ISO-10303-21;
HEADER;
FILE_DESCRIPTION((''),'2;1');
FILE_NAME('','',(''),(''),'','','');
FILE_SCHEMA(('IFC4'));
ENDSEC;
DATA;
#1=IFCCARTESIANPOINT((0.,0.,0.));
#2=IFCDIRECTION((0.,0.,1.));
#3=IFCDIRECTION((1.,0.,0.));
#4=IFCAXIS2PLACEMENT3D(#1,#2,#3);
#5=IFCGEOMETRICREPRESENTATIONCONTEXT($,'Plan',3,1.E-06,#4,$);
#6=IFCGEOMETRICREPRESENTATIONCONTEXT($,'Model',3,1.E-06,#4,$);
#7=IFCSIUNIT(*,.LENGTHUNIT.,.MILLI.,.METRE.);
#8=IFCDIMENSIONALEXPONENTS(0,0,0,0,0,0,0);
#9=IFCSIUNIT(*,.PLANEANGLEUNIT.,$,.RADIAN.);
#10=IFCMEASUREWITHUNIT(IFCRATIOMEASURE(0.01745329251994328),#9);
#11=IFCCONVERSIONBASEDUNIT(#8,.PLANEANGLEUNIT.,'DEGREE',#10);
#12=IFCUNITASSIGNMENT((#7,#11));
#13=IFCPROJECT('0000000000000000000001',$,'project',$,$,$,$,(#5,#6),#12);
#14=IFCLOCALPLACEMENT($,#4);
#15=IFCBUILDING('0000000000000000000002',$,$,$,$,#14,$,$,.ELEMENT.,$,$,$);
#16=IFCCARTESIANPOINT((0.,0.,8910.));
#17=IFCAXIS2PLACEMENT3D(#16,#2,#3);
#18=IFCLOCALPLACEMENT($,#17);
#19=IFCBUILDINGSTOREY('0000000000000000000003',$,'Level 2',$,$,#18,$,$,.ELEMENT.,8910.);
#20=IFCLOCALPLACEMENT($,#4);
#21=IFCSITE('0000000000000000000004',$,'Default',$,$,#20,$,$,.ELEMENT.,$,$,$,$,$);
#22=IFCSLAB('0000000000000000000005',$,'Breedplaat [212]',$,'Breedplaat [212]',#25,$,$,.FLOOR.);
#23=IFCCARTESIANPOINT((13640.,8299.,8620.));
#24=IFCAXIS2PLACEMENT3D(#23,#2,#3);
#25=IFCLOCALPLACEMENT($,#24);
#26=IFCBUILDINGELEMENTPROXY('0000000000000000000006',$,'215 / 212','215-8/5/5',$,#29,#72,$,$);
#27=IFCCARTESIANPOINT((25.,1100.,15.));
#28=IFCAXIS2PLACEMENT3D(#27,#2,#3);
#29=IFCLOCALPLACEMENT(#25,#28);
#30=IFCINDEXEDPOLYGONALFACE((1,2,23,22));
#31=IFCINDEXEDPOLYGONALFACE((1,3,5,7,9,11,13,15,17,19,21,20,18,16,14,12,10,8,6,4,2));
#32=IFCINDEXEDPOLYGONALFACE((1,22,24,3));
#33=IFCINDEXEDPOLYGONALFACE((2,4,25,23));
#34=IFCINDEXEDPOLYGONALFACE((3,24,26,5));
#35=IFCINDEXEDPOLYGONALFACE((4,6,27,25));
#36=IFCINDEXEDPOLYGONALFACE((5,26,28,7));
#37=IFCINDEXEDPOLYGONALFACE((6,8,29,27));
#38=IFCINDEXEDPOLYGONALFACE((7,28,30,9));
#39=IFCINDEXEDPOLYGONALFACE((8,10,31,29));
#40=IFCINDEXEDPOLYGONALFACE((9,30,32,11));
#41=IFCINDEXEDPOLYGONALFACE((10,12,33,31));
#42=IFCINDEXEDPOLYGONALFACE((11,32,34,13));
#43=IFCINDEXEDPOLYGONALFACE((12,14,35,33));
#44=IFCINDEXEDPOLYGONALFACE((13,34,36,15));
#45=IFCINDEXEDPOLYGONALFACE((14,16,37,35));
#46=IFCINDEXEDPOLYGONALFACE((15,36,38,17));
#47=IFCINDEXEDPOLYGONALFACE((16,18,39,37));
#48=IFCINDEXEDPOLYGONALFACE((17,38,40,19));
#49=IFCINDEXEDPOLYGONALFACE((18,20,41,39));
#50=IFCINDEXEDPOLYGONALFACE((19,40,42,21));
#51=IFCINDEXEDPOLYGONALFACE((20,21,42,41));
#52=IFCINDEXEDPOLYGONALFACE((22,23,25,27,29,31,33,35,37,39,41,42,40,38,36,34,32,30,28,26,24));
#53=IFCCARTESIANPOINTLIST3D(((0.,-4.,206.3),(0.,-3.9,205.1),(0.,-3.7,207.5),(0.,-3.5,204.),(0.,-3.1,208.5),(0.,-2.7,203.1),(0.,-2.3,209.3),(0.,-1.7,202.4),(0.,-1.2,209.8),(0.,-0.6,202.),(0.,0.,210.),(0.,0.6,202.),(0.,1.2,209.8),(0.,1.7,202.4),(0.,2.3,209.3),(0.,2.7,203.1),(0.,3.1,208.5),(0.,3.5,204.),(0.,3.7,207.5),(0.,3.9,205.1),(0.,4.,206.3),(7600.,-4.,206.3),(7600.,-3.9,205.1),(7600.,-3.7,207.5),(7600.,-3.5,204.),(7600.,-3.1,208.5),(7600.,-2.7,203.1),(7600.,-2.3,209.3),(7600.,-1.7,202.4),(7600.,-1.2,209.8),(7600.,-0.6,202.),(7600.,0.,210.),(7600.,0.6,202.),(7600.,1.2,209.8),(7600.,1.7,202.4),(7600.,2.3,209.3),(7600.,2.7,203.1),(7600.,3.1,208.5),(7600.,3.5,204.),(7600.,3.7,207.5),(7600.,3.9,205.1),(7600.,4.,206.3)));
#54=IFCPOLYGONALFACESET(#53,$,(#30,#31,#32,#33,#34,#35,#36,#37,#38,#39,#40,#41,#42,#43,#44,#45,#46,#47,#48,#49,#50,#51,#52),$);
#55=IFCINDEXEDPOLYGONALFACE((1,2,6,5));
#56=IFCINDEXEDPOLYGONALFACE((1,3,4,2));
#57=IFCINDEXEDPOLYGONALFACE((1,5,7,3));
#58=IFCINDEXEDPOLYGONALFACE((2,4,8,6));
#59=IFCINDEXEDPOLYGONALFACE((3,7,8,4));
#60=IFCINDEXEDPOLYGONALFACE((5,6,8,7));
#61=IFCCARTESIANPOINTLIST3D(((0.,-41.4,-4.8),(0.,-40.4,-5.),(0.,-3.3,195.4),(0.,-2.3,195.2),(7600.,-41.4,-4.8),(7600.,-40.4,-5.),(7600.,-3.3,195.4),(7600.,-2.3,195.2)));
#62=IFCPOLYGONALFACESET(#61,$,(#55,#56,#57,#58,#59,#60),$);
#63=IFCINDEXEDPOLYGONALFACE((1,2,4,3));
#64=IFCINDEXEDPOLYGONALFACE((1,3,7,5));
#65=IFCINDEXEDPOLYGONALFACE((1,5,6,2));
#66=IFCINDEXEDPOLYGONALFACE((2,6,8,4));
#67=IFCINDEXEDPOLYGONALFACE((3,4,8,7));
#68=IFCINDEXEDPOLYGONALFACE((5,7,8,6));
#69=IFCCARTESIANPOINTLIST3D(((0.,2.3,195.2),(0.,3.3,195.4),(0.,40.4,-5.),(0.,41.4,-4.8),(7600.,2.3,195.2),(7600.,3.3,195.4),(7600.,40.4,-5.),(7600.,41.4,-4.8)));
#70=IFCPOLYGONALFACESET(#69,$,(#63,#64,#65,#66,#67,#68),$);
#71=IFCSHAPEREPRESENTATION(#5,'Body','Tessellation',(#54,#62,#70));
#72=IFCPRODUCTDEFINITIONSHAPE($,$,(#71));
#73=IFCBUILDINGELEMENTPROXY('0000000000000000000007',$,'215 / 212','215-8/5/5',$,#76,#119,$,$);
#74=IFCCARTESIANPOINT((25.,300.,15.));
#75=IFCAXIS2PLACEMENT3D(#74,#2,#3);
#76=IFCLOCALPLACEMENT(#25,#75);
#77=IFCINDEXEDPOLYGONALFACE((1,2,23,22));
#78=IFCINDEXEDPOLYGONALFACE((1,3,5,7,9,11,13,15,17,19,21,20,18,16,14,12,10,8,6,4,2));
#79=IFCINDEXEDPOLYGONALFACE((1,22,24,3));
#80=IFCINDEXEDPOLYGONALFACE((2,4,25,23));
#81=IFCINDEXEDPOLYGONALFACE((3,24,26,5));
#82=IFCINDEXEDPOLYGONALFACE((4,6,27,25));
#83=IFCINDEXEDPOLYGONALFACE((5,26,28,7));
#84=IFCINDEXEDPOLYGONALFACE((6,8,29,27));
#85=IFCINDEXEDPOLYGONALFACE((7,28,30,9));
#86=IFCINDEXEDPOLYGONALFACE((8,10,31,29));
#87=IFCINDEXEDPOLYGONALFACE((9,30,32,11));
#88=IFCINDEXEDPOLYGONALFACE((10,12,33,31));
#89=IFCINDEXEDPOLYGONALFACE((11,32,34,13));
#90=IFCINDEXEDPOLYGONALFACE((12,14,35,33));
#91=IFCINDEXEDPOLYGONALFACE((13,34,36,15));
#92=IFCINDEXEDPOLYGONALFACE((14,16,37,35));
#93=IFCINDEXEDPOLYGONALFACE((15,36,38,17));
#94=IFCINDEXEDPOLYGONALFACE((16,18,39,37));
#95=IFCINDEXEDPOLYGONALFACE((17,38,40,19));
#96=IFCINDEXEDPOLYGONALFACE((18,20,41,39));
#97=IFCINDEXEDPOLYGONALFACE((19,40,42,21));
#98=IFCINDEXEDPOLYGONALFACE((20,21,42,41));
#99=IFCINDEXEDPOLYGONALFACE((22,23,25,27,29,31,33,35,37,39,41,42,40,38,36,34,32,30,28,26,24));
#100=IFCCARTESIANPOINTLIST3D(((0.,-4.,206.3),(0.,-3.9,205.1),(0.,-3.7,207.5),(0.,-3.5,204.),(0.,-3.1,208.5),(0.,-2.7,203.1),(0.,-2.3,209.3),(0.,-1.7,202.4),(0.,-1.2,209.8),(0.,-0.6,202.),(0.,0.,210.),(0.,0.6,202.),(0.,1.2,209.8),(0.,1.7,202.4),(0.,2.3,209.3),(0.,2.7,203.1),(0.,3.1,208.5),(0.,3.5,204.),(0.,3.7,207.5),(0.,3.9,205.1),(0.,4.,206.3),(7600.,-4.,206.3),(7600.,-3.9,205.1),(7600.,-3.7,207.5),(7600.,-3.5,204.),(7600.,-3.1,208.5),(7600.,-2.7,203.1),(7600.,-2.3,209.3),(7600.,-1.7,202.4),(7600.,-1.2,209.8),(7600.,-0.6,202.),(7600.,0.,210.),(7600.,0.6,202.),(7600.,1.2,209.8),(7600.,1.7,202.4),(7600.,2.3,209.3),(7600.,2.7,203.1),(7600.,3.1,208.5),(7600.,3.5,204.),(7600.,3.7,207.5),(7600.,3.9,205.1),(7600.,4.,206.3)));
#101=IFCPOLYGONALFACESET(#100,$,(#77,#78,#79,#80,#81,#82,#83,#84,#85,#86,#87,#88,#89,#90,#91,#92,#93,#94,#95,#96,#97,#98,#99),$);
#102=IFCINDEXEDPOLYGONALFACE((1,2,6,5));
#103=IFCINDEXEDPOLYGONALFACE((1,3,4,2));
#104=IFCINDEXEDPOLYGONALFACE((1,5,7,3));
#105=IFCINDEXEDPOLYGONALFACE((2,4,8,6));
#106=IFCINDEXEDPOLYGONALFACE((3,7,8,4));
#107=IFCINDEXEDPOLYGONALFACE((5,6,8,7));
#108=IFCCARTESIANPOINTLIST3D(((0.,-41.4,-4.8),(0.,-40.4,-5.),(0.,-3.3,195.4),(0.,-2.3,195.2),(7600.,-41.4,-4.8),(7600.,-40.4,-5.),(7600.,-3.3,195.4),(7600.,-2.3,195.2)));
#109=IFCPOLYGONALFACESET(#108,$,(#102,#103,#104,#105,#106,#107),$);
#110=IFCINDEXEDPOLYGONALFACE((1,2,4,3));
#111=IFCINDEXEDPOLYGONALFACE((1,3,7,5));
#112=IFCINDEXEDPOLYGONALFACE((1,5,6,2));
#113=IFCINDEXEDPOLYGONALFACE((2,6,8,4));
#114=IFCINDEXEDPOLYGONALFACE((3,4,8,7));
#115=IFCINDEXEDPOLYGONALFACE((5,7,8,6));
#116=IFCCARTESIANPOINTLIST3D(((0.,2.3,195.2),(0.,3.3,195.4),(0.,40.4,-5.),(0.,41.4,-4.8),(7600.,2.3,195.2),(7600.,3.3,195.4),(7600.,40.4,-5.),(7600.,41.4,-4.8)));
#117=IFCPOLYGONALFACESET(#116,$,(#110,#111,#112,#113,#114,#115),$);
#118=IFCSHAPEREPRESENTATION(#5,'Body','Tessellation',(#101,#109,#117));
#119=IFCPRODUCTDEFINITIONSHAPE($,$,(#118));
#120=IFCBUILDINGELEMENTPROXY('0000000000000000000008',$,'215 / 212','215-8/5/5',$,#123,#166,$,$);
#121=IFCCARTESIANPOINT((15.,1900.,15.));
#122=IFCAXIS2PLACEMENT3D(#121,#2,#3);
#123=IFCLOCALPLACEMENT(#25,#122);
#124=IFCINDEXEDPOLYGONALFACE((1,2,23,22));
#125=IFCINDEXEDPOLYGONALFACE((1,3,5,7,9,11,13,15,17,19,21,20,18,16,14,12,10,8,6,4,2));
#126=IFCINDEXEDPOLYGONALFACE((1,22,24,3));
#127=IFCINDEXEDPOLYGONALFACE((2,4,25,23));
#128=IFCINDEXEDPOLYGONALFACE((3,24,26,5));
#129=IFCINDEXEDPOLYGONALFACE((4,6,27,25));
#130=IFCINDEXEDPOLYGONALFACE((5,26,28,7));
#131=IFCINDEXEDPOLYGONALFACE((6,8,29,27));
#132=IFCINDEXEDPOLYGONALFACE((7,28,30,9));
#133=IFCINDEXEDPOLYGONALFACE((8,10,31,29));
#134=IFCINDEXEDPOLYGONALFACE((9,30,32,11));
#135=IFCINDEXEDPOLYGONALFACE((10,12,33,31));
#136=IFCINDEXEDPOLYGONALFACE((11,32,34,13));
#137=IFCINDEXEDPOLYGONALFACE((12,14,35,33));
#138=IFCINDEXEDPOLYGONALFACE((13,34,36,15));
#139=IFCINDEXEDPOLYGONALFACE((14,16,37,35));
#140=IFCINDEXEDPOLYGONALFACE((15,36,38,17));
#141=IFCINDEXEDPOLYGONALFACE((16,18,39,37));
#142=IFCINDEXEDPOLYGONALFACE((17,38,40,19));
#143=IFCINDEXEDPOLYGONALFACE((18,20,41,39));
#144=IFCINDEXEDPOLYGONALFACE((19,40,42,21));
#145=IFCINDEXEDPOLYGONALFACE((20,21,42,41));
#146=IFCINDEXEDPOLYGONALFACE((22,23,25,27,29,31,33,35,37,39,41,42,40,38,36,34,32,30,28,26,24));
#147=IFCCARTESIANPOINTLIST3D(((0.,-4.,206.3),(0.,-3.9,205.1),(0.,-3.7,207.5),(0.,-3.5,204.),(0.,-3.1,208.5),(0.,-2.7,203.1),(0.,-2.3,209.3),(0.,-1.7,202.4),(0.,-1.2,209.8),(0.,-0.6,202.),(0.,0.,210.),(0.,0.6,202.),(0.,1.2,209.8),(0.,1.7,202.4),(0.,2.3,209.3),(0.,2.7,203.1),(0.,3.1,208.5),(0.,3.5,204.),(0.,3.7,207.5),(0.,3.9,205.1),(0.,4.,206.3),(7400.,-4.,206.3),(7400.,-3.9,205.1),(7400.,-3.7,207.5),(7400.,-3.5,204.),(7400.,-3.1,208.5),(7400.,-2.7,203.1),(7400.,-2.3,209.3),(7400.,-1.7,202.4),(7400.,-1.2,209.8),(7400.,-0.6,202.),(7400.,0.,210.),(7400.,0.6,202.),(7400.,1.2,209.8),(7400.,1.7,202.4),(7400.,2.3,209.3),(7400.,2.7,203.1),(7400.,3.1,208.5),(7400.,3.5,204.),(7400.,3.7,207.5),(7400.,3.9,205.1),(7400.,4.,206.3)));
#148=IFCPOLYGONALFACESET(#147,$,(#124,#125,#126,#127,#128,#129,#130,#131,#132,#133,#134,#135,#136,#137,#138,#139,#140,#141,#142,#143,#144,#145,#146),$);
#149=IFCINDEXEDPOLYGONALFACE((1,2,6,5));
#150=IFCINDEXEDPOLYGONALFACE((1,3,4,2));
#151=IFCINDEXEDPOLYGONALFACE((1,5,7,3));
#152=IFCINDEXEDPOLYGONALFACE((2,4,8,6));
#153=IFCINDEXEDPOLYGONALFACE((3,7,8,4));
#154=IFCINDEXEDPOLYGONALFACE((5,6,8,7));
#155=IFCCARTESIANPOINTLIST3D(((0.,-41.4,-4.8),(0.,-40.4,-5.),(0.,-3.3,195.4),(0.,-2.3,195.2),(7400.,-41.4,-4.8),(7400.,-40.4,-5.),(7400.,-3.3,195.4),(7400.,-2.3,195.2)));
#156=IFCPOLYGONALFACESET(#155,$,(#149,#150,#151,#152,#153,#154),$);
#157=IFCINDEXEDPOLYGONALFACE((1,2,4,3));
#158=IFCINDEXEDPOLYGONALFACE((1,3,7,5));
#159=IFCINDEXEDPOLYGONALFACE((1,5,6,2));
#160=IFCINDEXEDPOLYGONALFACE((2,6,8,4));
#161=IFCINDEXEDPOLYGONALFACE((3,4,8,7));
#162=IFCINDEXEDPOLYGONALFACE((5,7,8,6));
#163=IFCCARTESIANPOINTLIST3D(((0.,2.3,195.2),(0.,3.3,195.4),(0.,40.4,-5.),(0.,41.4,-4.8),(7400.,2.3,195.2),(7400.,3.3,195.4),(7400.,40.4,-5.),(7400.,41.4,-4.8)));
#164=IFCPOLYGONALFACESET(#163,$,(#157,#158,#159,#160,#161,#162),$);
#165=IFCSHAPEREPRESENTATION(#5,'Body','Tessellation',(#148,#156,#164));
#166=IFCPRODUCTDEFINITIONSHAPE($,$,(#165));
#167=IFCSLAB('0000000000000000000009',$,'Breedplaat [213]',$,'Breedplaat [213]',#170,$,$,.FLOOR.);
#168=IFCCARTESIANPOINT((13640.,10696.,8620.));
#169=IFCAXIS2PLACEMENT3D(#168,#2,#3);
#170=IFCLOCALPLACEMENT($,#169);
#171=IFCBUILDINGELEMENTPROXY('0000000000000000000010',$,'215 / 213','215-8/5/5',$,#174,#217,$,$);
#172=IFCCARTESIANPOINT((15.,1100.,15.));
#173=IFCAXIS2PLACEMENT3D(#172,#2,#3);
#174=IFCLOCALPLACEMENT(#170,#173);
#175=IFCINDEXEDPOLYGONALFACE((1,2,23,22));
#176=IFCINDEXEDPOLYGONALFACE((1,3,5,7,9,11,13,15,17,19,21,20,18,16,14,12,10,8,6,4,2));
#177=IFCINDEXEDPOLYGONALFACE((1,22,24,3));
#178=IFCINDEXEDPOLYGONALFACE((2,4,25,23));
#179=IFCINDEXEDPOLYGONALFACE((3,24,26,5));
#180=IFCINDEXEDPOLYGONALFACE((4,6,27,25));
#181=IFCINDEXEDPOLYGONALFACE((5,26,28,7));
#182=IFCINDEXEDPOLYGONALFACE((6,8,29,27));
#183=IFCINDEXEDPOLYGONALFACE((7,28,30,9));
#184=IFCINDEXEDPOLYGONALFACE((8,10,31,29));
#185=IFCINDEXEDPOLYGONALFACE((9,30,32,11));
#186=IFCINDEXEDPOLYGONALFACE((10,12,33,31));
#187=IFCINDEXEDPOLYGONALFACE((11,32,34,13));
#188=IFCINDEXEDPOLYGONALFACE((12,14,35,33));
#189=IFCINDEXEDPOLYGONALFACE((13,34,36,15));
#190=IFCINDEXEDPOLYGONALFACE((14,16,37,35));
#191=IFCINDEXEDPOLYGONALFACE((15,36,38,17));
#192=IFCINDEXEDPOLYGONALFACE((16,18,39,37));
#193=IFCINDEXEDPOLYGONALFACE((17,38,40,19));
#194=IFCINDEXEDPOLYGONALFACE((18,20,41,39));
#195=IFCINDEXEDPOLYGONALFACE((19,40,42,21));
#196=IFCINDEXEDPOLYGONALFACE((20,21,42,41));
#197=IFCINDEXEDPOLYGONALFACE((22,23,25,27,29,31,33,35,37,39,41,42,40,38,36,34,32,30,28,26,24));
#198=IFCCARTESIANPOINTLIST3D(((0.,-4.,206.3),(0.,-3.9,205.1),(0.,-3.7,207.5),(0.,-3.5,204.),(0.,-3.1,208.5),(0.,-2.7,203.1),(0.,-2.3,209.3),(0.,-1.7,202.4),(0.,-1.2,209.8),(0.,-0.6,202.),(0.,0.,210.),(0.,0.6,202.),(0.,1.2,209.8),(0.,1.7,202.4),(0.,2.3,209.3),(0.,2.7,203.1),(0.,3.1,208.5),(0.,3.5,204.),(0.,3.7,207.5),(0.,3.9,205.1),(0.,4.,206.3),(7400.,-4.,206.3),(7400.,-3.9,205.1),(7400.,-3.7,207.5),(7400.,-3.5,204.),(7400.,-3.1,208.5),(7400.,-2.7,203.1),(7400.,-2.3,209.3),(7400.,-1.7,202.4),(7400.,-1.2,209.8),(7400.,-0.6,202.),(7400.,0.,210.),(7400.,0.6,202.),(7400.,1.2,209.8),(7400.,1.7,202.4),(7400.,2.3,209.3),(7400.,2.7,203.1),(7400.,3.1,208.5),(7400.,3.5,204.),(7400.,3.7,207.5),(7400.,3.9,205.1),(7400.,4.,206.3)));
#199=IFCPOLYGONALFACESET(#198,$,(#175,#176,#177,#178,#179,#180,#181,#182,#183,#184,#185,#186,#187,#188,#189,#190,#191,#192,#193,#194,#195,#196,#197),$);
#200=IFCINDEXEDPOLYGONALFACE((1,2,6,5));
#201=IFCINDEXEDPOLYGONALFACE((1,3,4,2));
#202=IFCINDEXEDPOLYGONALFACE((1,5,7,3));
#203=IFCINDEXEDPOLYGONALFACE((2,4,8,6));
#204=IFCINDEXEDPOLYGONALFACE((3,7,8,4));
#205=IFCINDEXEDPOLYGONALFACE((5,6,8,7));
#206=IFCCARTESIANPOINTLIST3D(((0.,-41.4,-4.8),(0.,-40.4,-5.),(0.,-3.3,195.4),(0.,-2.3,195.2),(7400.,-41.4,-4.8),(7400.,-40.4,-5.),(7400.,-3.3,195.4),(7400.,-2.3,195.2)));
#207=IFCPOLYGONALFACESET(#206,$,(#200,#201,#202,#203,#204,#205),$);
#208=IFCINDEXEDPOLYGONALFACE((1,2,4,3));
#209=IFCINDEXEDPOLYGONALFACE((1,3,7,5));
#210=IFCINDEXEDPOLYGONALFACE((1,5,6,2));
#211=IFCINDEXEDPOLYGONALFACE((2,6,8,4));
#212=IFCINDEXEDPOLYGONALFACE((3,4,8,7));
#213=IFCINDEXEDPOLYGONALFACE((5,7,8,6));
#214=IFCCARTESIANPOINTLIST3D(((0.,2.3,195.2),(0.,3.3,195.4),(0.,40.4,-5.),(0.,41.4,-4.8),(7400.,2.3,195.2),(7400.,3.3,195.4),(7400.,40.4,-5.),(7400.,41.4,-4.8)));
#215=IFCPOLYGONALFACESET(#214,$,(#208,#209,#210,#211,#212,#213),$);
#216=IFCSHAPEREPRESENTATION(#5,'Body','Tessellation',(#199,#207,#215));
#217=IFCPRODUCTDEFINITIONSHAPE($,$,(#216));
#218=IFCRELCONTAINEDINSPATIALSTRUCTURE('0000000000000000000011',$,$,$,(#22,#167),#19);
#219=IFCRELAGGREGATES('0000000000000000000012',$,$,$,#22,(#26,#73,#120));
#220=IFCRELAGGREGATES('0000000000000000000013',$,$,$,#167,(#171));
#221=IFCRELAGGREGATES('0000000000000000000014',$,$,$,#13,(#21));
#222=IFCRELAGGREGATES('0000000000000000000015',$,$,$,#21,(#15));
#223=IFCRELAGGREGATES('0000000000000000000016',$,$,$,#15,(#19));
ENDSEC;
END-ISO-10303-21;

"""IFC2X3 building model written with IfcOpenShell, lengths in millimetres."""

from ifc_helpers import new_model, entity, si_unit, converted_unit, frame, origin_with_axes, origin_2d_with_axis, place, context, project, spatial, rectangle, circle, extrude, element, aggregate, save


model = new_model("IFC2X3")

# Units and contexts
plan_context = context("Plan", 3, precision=1e-06, world=origin_with_axes())
model_context = context("Model", 3, precision=1e-06, world=origin_with_axes())
ifc_project = project(units=[si_unit("LENGTHUNIT", "METRE", prefix="MILLI"), converted_unit("PLANEANGLEUNIT", "DEGREE", entity("IfcRatioMeasure", 0.01745329251994328), si_unit("PLANEANGLEUNIT", "RADIAN"), dimensions=[0, 0, 0, 0, 0, 0, 0])], contexts=[plan_context, model_context])

# Site, building, storey
site_placement = place(None, origin_with_axes())
site = spatial("IfcSite", under=ifc_project, at=site_placement, Name="Default", CompositionType="ELEMENT")
building_placement = place(None, origin_with_axes())
building = spatial("IfcBuilding", under=site, at=building_placement, CompositionType="ELEMENT")
storey_placement = place(None, frame((0.0, 0.0, 8910.0), z_axis=(0.0, 0.0, 1.0), x_axis=(1.0, 0.0, 0.0)))
storey = spatial("IfcBuildingStorey", under=building, at=storey_placement, Name="Level 2", CompositionType="ELEMENT", Elevation=8910.0)

# Slabs, building element proxies
slab_1_placement = place(None, frame((13640.0, 8299.0, 8620.0), z_axis=(0.0, 0.0, 1.0), x_axis=(1.0, 0.0, 0.0)))
slab_1 = element("IfcSlab", 1, at=slab_1_placement, inside=storey, Name="Breedplaat [212]", ObjectType="Breedplaat [212]", PredefinedType="FLOOR")
proxy_1_placement = place(slab_1_placement, frame((25.0, 1100.0, 15.0), z_axis=(0.0, 0.0, 1.0), x_axis=(1.0, 0.0, 0.0)))
proxy_1 = element("IfcBuildingElementProxy", 2, at=proxy_1_placement, Name="215 / 212", Description="215-8/5/5", context=plan_context, shape_type="SweptSolid", body=[
    extrude(circle(Radius=4.0, at=origin_2d_with_axis()), frame((0.0, 0.0, 206.0), z_axis=(1.0, 0.0, 0.0), x_axis=(0.0, 0.0, 1.0)), (0.0, 0.0, 1.0), 7600.0),
    extrude(rectangle(XDim=203.8, YDim=1.0, at=origin_2d_with_axis()), frame((0.0, -21.9, 95.2), z_axis=(1.0, 0.0, 0.0), x_axis=(0.0, 0.187112, 0.982339)), (0.0, 0.0, 1.0), 7600.0),
    extrude(rectangle(XDim=203.8, YDim=1.0, at=origin_2d_with_axis()), frame((0.0, 21.9, 95.2), z_axis=(1.0, 0.0, 0.0), x_axis=(0.0, -0.187112, 0.982339)), (0.0, 0.0, 1.0), 7600.0),
])
proxy_2_placement = place(slab_1_placement, frame((25.0, 300.0, 15.0), z_axis=(0.0, 0.0, 1.0), x_axis=(1.0, 0.0, 0.0)))
proxy_2 = element("IfcBuildingElementProxy", 3, at=proxy_2_placement, Name="215 / 212", Description="215-8/5/5", context=plan_context, shape_type="SweptSolid", body=[
    extrude(circle(Radius=4.0, at=origin_2d_with_axis()), frame((0.0, 0.0, 206.0), z_axis=(1.0, 0.0, 0.0), x_axis=(0.0, 0.0, 1.0)), (0.0, 0.0, 1.0), 7600.0),
    extrude(rectangle(XDim=203.8, YDim=1.0, at=origin_2d_with_axis()), frame((0.0, -21.9, 95.2), z_axis=(1.0, 0.0, 0.0), x_axis=(0.0, 0.187112, 0.982339)), (0.0, 0.0, 1.0), 7600.0),
    extrude(rectangle(XDim=203.8, YDim=1.0, at=origin_2d_with_axis()), frame((0.0, 21.9, 95.2), z_axis=(1.0, 0.0, 0.0), x_axis=(0.0, -0.187112, 0.982339)), (0.0, 0.0, 1.0), 7600.0),
])
proxy_3_placement = place(slab_1_placement, frame((15.0, 1900.0, 15.0), z_axis=(0.0, 0.0, 1.0), x_axis=(1.0, 0.0, 0.0)))
proxy_3 = element("IfcBuildingElementProxy", 4, at=proxy_3_placement, Name="215 / 212", Description="215-8/5/5", context=plan_context, shape_type="SweptSolid", body=[
    extrude(circle(Radius=4.0, at=origin_2d_with_axis()), frame((0.0, 0.0, 206.0), z_axis=(1.0, 0.0, 0.0), x_axis=(0.0, 0.0, 1.0)), (0.0, 0.0, 1.0), 7400.0),
    extrude(rectangle(XDim=203.8, YDim=1.0, at=origin_2d_with_axis()), frame((0.0, -21.9, 95.2), z_axis=(1.0, 0.0, 0.0), x_axis=(0.0, 0.187112, 0.982339)), (0.0, 0.0, 1.0), 7400.0),
    extrude(rectangle(XDim=203.8, YDim=1.0, at=origin_2d_with_axis()), frame((0.0, 21.9, 95.2), z_axis=(1.0, 0.0, 0.0), x_axis=(0.0, -0.187112, 0.982339)), (0.0, 0.0, 1.0), 7400.0),
])
aggregate(slab_1, [proxy_1, proxy_2, proxy_3])
slab_2_placement = place(None, frame((13640.0, 10696.0, 8620.0), z_axis=(0.0, 0.0, 1.0), x_axis=(1.0, 0.0, 0.0)))
slab_2 = element("IfcSlab", 5, at=slab_2_placement, inside=storey, Name="Breedplaat [213]", ObjectType="Breedplaat [213]", PredefinedType="FLOOR")
proxy_4_placement = place(slab_2_placement, frame((15.0, 1100.0, 15.0), z_axis=(0.0, 0.0, 1.0), x_axis=(1.0, 0.0, 0.0)))
proxy_4 = element("IfcBuildingElementProxy", 6, at=proxy_4_placement, Name="215 / 213", Description="215-8/5/5", context=plan_context, shape_type="SweptSolid", body=[
    extrude(circle(Radius=4.0, at=origin_2d_with_axis()), frame((0.0, 0.0, 206.0), z_axis=(1.0, 0.0, 0.0), x_axis=(0.0, 0.0, 1.0)), (0.0, 0.0, 1.0), 7400.0),
    extrude(rectangle(XDim=203.8, YDim=1.0, at=origin_2d_with_axis()), frame((0.0, -21.9, 95.2), z_axis=(1.0, 0.0, 0.0), x_axis=(0.0, 0.187112, 0.982339)), (0.0, 0.0, 1.0), 7400.0),
    extrude(rectangle(XDim=203.8, YDim=1.0, at=origin_2d_with_axis()), frame((0.0, 21.9, 95.2), z_axis=(1.0, 0.0, 0.0), x_axis=(0.0, -0.187112, 0.982339)), (0.0, 0.0, 1.0), 7400.0),
])
aggregate(slab_2, [proxy_4])

save(model, "model.ifc")
